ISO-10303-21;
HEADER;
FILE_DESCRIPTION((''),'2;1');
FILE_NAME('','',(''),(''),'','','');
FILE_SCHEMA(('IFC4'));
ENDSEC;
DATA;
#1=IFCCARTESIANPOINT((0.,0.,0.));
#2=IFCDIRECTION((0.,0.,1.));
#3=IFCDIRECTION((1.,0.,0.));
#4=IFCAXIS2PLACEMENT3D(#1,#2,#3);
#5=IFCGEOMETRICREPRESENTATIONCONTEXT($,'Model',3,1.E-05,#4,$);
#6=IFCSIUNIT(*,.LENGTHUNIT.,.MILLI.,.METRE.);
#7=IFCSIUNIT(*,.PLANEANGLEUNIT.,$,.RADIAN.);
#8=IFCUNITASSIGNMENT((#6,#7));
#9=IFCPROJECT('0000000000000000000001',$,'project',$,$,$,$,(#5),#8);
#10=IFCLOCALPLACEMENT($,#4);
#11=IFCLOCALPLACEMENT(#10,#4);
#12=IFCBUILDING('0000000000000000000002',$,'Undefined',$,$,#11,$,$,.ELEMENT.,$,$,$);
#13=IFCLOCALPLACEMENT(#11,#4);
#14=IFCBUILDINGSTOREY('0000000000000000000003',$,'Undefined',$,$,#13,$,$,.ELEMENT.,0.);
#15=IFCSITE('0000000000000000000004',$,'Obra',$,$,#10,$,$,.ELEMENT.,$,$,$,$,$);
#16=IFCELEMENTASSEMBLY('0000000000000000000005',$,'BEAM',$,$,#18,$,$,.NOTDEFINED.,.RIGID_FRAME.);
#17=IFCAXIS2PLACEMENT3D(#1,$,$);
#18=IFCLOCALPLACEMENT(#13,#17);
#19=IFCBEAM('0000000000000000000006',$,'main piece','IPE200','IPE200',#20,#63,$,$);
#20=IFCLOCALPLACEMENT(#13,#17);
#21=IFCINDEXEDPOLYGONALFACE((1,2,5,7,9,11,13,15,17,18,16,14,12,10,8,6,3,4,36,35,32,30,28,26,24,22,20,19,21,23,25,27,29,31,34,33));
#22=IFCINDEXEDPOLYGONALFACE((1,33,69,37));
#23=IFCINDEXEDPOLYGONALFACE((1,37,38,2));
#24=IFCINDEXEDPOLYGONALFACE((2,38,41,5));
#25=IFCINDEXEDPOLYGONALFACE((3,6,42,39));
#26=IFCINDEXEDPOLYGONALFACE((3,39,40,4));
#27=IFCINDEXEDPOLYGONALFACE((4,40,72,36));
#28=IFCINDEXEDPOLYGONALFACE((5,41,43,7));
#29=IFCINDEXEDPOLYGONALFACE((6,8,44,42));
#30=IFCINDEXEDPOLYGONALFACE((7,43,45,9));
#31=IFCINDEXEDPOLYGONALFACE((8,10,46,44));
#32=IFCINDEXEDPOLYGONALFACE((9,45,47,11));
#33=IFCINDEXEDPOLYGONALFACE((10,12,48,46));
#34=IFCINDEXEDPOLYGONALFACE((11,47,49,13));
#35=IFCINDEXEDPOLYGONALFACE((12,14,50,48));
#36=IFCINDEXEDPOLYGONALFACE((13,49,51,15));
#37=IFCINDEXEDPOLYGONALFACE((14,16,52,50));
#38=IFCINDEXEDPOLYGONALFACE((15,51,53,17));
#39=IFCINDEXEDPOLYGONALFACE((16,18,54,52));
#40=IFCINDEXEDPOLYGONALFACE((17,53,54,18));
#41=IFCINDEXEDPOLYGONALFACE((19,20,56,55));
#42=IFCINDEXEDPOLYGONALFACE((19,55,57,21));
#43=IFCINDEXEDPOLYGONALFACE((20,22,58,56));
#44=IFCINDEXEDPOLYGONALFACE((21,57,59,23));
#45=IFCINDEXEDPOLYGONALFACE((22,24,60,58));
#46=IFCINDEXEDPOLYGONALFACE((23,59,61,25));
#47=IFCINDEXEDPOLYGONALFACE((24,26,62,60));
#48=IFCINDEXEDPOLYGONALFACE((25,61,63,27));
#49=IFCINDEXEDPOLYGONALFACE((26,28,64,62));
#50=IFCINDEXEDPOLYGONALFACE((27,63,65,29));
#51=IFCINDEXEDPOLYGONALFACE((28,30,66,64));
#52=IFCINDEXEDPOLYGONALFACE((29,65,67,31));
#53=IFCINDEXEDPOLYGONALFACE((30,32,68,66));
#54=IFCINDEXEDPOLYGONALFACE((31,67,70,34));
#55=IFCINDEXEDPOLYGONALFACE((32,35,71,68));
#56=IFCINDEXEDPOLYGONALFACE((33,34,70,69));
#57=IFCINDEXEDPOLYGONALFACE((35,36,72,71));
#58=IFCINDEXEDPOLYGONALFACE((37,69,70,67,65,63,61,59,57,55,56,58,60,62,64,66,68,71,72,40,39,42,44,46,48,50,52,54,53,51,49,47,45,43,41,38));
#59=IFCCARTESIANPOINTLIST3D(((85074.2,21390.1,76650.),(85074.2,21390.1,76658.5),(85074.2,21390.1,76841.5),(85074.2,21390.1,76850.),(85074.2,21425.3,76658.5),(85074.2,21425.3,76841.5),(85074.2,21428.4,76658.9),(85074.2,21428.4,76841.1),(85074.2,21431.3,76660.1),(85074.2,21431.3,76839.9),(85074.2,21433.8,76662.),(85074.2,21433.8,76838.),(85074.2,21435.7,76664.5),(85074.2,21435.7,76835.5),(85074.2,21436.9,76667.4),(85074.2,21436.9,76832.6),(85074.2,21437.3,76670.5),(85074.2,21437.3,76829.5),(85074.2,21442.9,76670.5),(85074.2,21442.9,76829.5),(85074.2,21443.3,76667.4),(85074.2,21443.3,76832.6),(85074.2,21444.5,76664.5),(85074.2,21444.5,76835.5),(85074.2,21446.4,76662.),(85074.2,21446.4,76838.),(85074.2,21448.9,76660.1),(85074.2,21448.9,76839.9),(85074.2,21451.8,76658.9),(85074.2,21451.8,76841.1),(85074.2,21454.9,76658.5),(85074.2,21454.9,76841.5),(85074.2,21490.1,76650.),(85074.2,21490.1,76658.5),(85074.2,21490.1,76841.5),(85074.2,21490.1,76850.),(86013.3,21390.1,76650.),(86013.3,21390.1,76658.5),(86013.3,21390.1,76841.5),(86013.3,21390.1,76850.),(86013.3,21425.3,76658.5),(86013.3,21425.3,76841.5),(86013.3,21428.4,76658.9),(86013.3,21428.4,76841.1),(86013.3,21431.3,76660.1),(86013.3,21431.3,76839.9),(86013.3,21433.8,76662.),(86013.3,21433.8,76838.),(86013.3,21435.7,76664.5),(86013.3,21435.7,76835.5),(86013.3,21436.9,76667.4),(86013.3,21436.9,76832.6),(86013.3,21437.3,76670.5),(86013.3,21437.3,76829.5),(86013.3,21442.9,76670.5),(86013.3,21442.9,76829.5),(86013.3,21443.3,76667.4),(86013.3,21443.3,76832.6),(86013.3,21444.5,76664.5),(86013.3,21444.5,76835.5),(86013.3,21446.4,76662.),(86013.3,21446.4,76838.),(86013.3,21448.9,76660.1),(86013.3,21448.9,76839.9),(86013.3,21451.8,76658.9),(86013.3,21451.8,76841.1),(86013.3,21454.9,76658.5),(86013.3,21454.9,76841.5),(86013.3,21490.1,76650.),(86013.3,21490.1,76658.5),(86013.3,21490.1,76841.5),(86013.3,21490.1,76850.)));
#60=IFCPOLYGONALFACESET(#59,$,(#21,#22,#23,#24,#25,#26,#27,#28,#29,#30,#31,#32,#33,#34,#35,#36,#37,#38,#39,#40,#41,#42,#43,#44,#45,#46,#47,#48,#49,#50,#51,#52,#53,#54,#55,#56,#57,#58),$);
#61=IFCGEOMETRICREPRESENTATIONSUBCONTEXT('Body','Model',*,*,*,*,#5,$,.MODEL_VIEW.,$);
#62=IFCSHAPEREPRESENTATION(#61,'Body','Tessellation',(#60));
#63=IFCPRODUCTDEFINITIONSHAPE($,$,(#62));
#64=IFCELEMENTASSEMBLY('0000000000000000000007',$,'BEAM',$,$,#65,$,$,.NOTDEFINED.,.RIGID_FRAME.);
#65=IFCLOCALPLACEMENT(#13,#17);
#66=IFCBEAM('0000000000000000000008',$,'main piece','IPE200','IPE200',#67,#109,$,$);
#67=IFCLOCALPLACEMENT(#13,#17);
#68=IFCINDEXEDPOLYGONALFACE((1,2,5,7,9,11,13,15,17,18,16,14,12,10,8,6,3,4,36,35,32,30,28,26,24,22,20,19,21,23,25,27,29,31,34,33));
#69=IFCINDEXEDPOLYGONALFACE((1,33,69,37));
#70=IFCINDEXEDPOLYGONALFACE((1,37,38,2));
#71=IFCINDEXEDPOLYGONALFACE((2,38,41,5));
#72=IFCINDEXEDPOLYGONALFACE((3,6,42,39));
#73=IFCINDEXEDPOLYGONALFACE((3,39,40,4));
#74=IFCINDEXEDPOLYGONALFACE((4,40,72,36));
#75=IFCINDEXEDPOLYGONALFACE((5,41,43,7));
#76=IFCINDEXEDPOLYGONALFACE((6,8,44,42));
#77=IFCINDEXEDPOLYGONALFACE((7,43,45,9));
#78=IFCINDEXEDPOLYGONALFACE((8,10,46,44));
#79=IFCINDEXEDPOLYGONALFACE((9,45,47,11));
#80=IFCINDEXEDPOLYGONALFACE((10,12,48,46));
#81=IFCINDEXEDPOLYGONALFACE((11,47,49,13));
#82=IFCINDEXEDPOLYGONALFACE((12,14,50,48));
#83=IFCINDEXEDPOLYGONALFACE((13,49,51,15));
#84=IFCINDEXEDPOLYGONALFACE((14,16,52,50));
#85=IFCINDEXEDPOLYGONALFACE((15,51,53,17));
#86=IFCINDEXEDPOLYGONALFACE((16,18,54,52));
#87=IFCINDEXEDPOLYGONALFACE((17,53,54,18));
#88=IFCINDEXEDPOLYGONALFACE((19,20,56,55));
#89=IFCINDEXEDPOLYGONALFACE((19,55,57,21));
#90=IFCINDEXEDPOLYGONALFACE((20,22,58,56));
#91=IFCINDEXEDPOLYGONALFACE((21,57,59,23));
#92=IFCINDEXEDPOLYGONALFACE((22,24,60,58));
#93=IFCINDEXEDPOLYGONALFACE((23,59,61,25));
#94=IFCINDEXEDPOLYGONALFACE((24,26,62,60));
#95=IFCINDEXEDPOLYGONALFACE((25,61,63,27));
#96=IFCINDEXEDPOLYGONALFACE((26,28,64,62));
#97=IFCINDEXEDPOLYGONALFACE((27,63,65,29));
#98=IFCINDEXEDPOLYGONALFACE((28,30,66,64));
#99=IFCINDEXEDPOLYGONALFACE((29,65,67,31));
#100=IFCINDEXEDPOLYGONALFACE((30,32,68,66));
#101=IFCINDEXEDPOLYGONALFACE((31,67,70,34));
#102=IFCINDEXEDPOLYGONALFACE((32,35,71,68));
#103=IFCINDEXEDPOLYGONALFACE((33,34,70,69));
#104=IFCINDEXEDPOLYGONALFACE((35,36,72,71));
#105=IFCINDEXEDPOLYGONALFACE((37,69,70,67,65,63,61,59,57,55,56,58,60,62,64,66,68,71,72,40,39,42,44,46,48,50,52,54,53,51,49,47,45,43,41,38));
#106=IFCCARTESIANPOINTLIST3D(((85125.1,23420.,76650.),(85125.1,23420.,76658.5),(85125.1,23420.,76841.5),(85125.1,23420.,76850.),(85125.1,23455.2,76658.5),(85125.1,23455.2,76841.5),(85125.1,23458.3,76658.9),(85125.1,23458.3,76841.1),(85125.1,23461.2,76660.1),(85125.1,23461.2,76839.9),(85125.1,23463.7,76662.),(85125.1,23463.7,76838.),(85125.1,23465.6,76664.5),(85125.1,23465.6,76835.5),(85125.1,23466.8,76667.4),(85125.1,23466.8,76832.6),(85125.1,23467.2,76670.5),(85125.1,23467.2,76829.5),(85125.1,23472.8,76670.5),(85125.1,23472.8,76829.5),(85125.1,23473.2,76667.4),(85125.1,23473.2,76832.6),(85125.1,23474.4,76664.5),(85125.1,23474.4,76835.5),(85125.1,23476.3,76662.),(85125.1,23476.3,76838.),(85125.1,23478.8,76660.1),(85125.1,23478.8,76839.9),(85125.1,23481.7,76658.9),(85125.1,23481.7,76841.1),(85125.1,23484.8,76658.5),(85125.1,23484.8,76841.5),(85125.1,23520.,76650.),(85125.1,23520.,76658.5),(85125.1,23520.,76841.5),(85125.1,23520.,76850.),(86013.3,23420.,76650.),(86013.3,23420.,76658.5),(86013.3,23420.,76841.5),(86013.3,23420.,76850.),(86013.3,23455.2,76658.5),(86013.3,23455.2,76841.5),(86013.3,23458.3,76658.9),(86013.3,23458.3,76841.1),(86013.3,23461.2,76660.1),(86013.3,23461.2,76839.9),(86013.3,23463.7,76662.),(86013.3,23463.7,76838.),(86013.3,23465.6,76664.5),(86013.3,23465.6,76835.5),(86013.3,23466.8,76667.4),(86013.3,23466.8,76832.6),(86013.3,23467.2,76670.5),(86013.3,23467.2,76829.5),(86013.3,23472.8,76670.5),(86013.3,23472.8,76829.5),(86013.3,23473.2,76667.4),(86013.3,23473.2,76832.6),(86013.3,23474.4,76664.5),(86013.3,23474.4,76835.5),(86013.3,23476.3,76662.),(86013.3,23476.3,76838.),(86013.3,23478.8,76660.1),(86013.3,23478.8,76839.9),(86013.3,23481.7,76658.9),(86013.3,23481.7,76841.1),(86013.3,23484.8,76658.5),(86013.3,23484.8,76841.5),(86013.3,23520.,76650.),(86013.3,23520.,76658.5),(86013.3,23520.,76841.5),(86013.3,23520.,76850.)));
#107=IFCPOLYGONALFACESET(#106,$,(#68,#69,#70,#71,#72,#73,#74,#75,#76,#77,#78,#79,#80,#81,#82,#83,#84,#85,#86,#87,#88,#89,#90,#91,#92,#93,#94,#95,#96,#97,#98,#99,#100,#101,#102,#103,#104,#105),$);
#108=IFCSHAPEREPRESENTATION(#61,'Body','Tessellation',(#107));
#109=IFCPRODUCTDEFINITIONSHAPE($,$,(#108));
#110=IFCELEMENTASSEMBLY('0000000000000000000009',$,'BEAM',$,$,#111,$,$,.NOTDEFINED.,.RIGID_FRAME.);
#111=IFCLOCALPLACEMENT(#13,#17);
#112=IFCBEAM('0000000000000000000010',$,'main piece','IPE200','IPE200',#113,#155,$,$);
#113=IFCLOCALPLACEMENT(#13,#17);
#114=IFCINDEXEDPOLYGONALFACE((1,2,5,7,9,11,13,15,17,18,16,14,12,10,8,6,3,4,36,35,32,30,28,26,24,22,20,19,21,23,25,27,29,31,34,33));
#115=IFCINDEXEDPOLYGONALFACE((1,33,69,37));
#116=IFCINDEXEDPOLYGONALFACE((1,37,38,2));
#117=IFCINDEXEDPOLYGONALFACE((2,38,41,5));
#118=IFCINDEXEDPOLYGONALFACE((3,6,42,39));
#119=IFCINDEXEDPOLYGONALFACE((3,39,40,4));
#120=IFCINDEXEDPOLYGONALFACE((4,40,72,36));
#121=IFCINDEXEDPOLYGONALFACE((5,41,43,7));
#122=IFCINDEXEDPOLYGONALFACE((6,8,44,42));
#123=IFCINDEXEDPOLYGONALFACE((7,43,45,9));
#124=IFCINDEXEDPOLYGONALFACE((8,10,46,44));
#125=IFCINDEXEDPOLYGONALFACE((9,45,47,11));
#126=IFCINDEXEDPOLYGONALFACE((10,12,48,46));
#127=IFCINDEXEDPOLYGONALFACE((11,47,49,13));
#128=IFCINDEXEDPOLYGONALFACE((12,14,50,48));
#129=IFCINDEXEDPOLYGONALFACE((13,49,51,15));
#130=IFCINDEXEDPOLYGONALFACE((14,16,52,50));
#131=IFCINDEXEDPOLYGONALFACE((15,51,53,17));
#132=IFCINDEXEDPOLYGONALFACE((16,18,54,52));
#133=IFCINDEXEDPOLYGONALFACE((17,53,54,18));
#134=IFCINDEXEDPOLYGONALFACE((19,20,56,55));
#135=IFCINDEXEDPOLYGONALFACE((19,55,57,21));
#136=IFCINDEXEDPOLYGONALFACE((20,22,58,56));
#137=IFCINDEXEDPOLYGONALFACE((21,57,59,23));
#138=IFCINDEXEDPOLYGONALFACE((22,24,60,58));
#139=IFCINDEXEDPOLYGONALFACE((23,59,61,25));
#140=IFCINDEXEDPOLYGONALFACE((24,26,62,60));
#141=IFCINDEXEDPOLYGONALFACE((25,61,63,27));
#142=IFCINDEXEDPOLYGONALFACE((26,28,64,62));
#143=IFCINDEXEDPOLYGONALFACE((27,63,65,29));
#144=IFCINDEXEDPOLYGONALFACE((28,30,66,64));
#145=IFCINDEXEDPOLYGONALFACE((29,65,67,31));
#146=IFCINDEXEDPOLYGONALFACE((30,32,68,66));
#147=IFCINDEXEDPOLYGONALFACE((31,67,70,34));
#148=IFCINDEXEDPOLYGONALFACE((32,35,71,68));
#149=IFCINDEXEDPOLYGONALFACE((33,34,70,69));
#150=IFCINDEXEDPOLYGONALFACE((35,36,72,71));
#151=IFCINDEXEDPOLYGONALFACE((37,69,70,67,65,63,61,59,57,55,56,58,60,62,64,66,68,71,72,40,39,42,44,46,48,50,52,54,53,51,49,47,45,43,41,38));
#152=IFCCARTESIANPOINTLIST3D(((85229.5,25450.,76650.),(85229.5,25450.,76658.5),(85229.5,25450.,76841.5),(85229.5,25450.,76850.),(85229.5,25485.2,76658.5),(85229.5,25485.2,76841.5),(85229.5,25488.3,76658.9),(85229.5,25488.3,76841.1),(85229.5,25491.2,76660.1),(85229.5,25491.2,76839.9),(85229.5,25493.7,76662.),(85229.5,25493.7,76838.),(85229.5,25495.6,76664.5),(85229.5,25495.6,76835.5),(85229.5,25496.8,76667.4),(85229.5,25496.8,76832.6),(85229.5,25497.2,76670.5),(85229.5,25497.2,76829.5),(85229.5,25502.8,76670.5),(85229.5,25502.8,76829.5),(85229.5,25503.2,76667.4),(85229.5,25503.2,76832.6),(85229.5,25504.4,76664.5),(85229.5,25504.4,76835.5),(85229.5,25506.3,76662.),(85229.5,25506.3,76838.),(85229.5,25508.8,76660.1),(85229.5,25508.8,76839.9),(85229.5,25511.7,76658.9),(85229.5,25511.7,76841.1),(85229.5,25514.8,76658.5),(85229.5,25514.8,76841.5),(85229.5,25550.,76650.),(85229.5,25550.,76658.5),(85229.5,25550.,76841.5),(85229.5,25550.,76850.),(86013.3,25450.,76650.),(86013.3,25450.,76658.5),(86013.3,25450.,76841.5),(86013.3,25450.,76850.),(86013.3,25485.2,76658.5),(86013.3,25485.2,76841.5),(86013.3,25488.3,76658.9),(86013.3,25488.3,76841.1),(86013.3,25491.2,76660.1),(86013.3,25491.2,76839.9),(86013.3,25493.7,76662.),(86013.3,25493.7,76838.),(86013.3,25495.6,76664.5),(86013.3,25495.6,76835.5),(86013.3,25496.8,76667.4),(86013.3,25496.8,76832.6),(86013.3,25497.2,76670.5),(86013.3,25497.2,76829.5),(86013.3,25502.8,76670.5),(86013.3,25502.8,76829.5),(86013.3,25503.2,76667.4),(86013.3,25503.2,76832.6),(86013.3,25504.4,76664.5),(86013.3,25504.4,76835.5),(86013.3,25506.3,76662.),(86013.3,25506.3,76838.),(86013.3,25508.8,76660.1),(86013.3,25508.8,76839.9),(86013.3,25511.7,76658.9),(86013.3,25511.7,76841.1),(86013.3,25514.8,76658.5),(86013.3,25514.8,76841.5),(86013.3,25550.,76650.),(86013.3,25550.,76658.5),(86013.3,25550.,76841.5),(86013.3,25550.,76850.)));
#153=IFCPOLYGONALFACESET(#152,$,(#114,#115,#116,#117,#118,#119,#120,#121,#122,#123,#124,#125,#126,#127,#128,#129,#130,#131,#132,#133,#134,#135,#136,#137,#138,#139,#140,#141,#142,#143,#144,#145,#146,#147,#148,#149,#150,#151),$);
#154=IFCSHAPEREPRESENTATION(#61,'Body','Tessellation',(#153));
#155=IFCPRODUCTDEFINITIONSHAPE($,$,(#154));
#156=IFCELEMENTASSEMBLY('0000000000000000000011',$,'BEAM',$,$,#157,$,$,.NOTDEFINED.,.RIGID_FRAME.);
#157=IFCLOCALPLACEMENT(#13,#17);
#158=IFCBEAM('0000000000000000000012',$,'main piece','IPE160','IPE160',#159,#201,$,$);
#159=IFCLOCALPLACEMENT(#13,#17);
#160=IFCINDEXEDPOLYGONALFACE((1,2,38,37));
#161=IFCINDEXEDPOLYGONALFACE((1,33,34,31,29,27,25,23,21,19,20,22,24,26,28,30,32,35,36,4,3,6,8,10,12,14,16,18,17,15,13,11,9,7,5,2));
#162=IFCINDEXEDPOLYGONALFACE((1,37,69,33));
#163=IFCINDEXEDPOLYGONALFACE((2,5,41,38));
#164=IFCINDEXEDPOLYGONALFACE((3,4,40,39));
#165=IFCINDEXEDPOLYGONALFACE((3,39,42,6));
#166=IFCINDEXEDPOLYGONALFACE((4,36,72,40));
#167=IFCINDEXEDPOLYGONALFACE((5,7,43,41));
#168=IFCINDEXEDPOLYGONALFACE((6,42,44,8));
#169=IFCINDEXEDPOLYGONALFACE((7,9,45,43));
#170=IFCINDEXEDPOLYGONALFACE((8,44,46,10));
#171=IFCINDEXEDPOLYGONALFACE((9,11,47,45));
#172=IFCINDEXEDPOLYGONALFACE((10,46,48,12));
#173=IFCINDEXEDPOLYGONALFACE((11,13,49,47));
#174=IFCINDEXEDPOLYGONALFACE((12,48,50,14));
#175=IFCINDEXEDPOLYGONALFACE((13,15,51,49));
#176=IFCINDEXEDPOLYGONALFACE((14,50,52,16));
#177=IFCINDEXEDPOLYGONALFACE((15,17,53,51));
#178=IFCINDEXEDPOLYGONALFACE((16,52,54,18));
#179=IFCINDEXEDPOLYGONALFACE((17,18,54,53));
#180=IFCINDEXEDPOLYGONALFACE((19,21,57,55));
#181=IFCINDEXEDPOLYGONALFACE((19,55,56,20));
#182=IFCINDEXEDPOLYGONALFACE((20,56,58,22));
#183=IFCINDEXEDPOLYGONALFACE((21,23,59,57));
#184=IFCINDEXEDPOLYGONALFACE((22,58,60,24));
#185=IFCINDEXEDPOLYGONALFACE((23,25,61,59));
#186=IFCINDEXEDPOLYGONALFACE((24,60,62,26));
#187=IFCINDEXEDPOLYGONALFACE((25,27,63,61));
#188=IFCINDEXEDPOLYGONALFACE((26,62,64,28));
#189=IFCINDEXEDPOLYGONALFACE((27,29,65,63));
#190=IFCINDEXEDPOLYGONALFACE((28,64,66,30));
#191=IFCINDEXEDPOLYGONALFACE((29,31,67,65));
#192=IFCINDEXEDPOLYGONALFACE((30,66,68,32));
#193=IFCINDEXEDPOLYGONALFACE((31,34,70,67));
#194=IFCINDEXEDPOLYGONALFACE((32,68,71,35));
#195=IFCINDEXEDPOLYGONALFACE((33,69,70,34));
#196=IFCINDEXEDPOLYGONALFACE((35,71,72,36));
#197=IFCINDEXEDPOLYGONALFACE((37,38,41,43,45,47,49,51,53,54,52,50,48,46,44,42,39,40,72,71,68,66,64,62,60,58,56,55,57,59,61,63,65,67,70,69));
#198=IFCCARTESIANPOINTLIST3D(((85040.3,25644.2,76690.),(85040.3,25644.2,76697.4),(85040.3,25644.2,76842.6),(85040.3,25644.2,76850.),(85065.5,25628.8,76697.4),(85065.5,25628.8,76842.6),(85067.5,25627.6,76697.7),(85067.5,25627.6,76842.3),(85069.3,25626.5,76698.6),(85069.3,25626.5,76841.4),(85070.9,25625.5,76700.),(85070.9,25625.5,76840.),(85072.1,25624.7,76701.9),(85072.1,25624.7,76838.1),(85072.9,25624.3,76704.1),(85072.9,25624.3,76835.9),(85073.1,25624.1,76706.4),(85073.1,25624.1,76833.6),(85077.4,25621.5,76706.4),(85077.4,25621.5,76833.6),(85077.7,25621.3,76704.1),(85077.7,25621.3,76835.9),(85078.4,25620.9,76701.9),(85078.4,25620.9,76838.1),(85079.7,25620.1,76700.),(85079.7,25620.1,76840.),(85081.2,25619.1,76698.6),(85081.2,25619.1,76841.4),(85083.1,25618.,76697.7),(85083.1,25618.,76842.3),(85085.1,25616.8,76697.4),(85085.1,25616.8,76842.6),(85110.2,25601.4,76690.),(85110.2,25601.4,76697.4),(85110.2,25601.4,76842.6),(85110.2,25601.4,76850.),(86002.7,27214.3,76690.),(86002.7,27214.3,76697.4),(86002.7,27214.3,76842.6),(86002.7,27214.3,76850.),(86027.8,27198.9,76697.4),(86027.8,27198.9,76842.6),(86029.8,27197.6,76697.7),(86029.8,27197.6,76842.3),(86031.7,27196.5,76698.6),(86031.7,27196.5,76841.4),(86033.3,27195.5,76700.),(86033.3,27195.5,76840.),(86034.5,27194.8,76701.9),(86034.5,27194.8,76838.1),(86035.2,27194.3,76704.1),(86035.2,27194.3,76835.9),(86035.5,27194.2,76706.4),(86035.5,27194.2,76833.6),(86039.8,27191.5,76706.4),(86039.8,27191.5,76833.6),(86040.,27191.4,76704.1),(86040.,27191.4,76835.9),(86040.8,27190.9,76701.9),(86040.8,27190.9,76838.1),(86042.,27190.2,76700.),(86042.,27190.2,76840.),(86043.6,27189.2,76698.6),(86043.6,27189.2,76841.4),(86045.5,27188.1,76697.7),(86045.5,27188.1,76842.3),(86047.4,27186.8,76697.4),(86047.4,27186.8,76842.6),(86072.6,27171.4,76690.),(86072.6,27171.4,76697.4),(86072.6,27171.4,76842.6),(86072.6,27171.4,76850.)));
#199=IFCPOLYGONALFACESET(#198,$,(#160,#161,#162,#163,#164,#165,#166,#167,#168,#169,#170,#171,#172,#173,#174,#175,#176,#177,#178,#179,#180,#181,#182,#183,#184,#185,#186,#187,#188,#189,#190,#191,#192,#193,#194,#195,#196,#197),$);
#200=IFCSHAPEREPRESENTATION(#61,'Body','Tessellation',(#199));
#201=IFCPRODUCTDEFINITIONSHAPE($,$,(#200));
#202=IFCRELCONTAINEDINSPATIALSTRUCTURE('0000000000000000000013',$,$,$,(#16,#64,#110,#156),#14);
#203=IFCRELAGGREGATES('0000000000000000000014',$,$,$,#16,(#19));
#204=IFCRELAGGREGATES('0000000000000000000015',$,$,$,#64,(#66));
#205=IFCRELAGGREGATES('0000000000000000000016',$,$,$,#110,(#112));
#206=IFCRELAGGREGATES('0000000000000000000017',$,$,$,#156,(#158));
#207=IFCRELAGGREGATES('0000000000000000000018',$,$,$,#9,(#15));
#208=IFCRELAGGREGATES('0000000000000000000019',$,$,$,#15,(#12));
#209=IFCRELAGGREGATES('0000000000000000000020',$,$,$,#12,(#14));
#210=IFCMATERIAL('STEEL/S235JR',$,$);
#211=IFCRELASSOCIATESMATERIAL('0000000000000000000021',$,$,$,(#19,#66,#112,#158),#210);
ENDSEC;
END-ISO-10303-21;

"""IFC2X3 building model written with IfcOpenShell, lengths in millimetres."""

from ifc_helpers import new_model, si_unit, frame, origin_with_axes, origin_2d_with_axis, place, context, subcontext, project, spatial, i_section, extrude, material, element, aggregate, save


model = new_model("IFC2X3")

# Units and contexts
model_context = context("Model", 3, precision=1e-05, world=origin_with_axes())
body_context = subcontext(model_context, "Body", "Model", "MODEL_VIEW")
ifc_project = project(units=[si_unit("LENGTHUNIT", "METRE", prefix="MILLI"), si_unit("PLANEANGLEUNIT", "RADIAN")], contexts=[model_context])

# Site, building, storey
site_placement = place(None, origin_with_axes())
site = spatial("IfcSite", under=ifc_project, at=site_placement, Name="Obra", CompositionType="ELEMENT")
building_placement = place(site_placement, origin_with_axes())
building = spatial("IfcBuilding", under=site, at=building_placement, Name="Undefined", CompositionType="ELEMENT")
storey_placement = place(building_placement, origin_with_axes())
storey = spatial("IfcBuildingStorey", under=building, at=storey_placement, Name="Undefined", CompositionType="ELEMENT", Elevation=0.0)

# Element assemblies, beams
ifc_material = material(Name="STEEL/S235JR")
assembly_1_placement = place(storey_placement, origin_with_axes())
assembly_1 = element("IfcElementAssembly", 1, at=assembly_1_placement, inside=storey, Name="BEAM", AssemblyPlace="NOTDEFINED", PredefinedType="RIGID_FRAME")
beam_1_placement = place(assembly_1_placement, frame((85074.2, 21440.1, 76750.0), z_axis=(0.0, 0.0, 1.0), x_axis=(1.0, 0.0, 0.0)))
beam_1 = element("IfcBeam", 2, at=beam_1_placement, material=ifc_material, Name="main piece", Description="IPE200", ObjectType="IPE200", context=body_context, shape_type="SweptSolid", body=[
    extrude(i_section(OverallWidth=100.0, OverallDepth=200.0, WebThickness=5.6, FlangeThickness=8.5, FilletRadius=12.0, at=origin_2d_with_axis()), frame((939.1, 0.0, 0.0), z_axis=(-1.0, 0.0, 0.0), x_axis=(0.0, -1.0, 0.0)), (0.0, 0.0, 1.0), 939.1),
])
aggregate(assembly_1, [beam_1])
assembly_2_placement = place(storey_placement, origin_with_axes())
assembly_2 = element("IfcElementAssembly", 3, at=assembly_2_placement, inside=storey, Name="BEAM", AssemblyPlace="NOTDEFINED", PredefinedType="RIGID_FRAME")
beam_2_placement = place(assembly_2_placement, frame((85125.0, 23470.0, 76750.0), z_axis=(0.0, 0.0, 1.0), x_axis=(1.0, 0.0, 0.0)))
beam_2 = element("IfcBeam", 4, at=beam_2_placement, material=ifc_material, Name="main piece", Description="IPE200", ObjectType="IPE200", context=body_context, shape_type="SweptSolid", body=[
    extrude(i_section(OverallWidth=100.0, OverallDepth=200.0, WebThickness=5.6, FlangeThickness=8.5, FilletRadius=12.0, at=origin_2d_with_axis()), frame((888.3, 0.0, 0.0), z_axis=(-1.0, 0.0, 0.0), x_axis=(0.0, -1.0, 0.0)), (0.0, 0.0, 1.0), 888.2),
])
aggregate(assembly_2, [beam_2])
assembly_3_placement = place(storey_placement, origin_with_axes())
assembly_3 = element("IfcElementAssembly", 5, at=assembly_3_placement, inside=storey, Name="BEAM", AssemblyPlace="NOTDEFINED", PredefinedType="RIGID_FRAME")
beam_3_placement = place(assembly_3_placement, frame((85229.5, 25500.0, 76750.0), z_axis=(0.0, 0.0, 1.0), x_axis=(1.0, 0.0, 0.0)))
beam_3 = element("IfcBeam", 6, at=beam_3_placement, material=ifc_material, Name="main piece", Description="IPE200", ObjectType="IPE200", context=body_context, shape_type="SweptSolid", body=[
    extrude(i_section(OverallWidth=100.0, OverallDepth=200.0, WebThickness=5.6, FlangeThickness=8.5, FilletRadius=12.0, at=origin_2d_with_axis()), frame((783.8, 0.0, 0.0), z_axis=(-1.0, 0.0, 0.0), x_axis=(0.0, -1.0, 0.0)), (0.0, 0.0, 1.0), 783.8),
])
aggregate(assembly_3, [beam_3])
assembly_4_placement = place(storey_placement, origin_with_axes())
assembly_4 = element("IfcElementAssembly", 7, at=assembly_4_placement, inside=storey, Name="BEAM", AssemblyPlace="NOTDEFINED", PredefinedType="RIGID_FRAME")
beam_4_placement = place(assembly_4_placement, frame((85075.3, 25622.8, 76770.0), z_axis=(0.0, 0.0, 1.0), x_axis=(0.522594, 0.852582, 0.0)))
beam_4 = element("IfcBeam", 8, at=beam_4_placement, material=ifc_material, Name="main piece", Description="IPE160", ObjectType="IPE160", context=body_context, shape_type="SweptSolid", body=[
    extrude(i_section(OverallWidth=82.0, OverallDepth=160.0, WebThickness=5.0, FlangeThickness=7.4, FilletRadius=9.0, at=origin_2d_with_axis()), frame((1841.5, 0.0, 0.0), z_axis=(-1.0, 0.0, 0.0), x_axis=(0.0, -1.0, 0.0)), (0.0, 0.0, 1.0), 1841.5),
])
aggregate(assembly_4, [beam_4])

save(model, "model.ifc")
